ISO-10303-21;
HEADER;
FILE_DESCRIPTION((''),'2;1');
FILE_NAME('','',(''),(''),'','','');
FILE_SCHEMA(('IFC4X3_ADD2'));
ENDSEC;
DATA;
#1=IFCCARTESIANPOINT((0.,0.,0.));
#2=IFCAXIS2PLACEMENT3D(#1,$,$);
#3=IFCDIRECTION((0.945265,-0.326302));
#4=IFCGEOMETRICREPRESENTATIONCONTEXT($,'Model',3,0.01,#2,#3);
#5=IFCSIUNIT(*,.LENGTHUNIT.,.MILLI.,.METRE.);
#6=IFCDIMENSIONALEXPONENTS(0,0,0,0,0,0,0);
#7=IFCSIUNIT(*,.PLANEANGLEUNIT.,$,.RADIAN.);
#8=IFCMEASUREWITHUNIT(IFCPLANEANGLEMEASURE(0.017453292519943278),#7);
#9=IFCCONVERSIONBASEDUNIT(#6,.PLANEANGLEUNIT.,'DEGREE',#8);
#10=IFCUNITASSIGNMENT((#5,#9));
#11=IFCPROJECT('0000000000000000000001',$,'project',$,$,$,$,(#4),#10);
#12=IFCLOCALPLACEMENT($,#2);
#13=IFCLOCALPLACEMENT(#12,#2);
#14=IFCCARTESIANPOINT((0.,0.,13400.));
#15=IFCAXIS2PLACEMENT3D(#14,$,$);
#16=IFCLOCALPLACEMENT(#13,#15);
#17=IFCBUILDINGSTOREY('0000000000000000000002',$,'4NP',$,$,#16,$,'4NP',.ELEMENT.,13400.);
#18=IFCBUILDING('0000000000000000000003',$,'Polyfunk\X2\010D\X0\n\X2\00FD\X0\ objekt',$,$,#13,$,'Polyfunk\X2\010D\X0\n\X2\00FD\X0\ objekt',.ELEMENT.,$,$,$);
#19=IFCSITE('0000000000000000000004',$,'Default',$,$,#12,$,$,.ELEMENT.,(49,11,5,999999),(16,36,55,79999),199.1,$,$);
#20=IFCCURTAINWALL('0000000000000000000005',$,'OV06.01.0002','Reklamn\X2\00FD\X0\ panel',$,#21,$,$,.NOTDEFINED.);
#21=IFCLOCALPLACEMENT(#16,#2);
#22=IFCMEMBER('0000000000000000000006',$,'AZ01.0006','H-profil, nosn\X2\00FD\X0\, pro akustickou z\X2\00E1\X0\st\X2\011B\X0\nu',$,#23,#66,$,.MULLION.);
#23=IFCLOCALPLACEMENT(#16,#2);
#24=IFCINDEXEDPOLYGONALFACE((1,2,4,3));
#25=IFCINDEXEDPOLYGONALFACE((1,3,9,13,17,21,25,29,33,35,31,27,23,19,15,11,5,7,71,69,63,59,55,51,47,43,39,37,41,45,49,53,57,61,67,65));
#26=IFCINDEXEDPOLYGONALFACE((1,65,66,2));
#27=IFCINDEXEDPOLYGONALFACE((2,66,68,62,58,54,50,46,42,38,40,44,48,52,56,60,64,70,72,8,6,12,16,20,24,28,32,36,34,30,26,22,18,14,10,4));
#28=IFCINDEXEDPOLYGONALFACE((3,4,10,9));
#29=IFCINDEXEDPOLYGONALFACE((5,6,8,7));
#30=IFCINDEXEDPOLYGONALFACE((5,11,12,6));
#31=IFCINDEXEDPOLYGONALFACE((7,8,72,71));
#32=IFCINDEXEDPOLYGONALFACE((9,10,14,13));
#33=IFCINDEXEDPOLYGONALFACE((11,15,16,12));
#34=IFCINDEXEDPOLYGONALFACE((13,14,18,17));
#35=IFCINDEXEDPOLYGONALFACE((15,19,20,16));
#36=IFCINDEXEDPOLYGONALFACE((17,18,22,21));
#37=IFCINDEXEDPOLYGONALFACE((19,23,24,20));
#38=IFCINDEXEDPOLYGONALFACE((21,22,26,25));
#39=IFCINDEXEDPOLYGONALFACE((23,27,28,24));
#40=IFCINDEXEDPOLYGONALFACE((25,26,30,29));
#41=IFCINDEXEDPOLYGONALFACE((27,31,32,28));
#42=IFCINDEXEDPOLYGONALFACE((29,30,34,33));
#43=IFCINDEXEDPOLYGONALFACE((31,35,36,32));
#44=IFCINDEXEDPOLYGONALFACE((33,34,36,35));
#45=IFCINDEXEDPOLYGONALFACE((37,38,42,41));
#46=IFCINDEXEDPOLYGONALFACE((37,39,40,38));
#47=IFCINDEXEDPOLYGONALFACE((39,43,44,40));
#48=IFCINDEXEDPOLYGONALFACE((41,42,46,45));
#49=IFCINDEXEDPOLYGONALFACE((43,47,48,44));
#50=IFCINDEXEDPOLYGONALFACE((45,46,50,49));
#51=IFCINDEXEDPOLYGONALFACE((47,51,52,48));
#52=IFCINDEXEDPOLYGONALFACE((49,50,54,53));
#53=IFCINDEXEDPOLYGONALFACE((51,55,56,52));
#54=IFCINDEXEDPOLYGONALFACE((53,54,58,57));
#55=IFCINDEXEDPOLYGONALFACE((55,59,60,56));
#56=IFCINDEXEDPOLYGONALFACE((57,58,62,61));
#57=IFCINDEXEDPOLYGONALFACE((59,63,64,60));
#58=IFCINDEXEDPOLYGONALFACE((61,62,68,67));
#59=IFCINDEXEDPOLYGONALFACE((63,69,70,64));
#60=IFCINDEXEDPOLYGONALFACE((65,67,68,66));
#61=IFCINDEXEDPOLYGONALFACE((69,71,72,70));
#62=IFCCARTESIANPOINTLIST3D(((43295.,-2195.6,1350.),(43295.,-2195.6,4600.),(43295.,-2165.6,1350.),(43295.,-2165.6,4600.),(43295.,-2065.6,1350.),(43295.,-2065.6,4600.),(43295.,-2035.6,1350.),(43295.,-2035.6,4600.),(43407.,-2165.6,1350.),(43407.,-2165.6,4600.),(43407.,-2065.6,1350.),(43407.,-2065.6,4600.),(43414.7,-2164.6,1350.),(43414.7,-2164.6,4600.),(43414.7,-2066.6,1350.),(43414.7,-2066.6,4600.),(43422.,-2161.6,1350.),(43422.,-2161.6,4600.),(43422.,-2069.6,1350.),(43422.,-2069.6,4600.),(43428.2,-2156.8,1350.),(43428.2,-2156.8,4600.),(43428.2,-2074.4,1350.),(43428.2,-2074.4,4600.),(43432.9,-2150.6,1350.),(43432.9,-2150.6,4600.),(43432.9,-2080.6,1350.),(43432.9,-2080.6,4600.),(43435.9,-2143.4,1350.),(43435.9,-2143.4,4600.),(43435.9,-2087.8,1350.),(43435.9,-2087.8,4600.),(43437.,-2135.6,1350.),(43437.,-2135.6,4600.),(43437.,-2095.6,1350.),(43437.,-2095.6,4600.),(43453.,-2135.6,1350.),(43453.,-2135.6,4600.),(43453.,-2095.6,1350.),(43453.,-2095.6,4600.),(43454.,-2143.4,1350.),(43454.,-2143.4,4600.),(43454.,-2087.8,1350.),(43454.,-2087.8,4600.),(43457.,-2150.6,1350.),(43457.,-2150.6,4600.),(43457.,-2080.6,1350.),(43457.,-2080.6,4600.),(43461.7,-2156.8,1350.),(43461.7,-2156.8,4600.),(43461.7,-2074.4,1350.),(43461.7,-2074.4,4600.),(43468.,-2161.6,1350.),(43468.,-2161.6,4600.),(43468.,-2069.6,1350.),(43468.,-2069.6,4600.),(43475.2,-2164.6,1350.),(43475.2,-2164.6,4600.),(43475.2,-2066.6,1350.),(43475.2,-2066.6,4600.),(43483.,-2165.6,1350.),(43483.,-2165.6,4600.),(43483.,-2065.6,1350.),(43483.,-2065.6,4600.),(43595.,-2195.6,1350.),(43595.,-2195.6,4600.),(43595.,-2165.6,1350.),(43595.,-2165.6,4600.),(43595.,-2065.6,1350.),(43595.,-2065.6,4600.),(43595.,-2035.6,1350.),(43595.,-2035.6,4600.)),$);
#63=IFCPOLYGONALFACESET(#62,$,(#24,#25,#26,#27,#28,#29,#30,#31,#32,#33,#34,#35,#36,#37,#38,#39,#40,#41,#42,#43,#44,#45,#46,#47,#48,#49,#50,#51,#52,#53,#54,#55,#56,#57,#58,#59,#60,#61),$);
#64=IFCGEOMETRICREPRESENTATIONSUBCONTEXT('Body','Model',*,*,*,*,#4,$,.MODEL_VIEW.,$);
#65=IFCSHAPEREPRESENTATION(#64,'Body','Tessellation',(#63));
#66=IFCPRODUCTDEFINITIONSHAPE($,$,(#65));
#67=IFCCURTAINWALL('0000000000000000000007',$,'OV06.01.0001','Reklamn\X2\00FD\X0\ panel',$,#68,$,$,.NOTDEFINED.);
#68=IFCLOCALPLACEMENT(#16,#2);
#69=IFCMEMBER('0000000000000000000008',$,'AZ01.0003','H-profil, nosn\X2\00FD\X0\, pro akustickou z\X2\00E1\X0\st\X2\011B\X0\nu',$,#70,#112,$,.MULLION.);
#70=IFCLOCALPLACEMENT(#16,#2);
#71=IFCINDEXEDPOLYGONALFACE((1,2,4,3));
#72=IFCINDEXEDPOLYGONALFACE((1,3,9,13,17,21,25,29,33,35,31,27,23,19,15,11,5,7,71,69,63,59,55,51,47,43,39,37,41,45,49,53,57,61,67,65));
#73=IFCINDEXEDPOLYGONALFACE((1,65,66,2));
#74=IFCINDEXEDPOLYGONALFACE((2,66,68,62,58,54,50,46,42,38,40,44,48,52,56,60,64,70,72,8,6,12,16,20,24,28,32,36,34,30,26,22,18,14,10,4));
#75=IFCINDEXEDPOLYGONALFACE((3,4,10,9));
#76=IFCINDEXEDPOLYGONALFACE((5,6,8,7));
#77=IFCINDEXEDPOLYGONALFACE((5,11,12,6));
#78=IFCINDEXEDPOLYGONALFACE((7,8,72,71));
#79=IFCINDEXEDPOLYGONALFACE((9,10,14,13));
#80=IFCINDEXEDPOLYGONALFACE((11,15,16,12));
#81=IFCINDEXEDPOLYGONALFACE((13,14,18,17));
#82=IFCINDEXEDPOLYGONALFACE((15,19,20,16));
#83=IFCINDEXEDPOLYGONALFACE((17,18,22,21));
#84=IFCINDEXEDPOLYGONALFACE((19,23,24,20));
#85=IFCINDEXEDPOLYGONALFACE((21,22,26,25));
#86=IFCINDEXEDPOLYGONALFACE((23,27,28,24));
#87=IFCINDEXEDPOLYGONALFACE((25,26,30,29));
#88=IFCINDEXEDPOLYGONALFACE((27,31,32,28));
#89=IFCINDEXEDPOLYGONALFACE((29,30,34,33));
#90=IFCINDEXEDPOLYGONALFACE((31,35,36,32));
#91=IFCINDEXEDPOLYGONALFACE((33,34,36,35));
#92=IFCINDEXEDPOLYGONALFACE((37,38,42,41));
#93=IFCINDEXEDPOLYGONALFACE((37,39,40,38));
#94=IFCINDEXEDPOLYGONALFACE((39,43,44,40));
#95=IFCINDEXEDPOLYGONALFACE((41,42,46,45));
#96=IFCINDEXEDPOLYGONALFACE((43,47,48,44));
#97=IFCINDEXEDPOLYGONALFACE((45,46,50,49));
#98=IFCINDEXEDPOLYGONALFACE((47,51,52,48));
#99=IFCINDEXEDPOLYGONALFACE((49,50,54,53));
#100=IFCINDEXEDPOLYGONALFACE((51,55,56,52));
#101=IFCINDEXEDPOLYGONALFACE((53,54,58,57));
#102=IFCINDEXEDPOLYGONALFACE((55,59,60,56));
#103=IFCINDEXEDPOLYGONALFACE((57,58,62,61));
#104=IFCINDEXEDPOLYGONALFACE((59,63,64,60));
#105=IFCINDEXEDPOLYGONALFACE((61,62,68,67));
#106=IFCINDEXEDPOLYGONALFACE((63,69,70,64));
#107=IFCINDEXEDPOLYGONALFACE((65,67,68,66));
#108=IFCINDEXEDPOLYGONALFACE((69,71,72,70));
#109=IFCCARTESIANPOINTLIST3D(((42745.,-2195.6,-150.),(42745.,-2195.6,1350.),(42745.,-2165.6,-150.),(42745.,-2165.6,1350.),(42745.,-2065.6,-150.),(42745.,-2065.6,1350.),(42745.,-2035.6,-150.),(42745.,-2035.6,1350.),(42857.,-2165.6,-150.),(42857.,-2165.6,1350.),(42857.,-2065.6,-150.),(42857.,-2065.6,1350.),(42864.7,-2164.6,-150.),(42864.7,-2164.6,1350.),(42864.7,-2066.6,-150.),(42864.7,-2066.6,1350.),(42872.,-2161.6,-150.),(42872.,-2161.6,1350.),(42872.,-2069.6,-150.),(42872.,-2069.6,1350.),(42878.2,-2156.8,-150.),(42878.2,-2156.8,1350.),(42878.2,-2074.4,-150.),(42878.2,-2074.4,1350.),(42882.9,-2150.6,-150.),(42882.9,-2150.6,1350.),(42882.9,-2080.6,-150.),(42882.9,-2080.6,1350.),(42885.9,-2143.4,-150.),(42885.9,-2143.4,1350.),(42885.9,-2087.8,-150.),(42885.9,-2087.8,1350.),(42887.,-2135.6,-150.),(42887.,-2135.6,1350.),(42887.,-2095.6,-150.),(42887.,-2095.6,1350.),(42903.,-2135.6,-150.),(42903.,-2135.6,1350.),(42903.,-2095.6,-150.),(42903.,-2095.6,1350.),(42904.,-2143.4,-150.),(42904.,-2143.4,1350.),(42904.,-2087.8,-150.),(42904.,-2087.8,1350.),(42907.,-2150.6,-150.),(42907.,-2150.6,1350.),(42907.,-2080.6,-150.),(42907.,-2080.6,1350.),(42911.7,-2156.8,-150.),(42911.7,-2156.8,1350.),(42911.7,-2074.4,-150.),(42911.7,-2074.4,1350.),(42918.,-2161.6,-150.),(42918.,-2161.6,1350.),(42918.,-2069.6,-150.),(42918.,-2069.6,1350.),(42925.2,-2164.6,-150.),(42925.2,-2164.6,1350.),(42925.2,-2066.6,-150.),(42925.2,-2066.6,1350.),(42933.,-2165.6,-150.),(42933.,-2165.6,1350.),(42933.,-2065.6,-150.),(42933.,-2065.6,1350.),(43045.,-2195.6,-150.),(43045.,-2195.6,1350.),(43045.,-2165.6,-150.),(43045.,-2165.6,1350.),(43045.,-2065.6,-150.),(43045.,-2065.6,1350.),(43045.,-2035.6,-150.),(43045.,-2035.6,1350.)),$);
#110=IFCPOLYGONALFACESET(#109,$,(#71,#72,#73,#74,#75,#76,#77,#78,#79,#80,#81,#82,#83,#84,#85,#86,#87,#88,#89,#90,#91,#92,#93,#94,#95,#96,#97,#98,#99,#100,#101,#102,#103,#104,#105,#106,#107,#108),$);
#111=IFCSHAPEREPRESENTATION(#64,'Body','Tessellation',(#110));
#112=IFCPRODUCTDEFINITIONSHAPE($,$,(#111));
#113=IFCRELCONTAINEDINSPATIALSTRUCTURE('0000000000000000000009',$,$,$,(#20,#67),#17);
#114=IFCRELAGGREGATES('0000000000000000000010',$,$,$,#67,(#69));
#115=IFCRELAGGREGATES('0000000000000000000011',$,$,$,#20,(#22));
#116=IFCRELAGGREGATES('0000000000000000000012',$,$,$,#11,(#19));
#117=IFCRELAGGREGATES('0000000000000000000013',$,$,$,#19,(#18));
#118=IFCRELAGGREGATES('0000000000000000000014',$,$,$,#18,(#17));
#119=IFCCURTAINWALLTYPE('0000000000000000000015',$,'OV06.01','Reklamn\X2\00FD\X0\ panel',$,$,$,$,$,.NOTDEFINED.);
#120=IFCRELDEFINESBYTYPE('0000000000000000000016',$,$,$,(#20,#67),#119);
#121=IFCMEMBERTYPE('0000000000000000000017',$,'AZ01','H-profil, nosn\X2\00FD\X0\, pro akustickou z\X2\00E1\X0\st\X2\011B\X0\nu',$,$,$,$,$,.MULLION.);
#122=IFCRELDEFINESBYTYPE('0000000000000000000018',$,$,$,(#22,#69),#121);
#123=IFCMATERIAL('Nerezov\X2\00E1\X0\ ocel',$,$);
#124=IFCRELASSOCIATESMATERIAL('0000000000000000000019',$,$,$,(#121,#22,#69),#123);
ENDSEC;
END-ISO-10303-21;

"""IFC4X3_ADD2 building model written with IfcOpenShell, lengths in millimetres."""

from ifc_helpers import new_model, entity, si_unit, converted_unit, direction, frame, frame_2d, origin, place, context, subcontext, project, spatial, polyline, circle_curve, parameter, trimmed, segment, composite_curve, outline, extrude, source, transform, mapped, material, material_profile, profile_set, profile_usage, type_object, element, aggregate, save


model = new_model("IFC4X3_ADD2")

# Units and contexts
model_context = context("Model", 3, precision=0.01, world=origin(), true_north=direction((0.945265, -0.326302)))
body_context = subcontext(model_context, "Body", "Model", "MODEL_VIEW")
ifc_project = project(units=[si_unit("LENGTHUNIT", "METRE", prefix="MILLI"), converted_unit("PLANEANGLEUNIT", "DEGREE", entity("IfcPlaneAngleMeasure", 0.017453292519943278), si_unit("PLANEANGLEUNIT", "RADIAN"), dimensions=[0, 0, 0, 0, 0, 0, 0])], contexts=[model_context])

# Site, building, storey
site_placement = place(None, origin())
site = spatial("IfcSite", under=ifc_project, at=site_placement, Name="Default", CompositionType="ELEMENT", RefLatitude=(49, 11, 5, 999999), RefLongitude=(16, 36, 55, 79999), RefElevation=199.1)
building_placement = place(site_placement, origin())
building = spatial("IfcBuilding", under=site, at=building_placement, Name="Polyfunkčný objekt", LongName="Polyfunkčný objekt", CompositionType="ELEMENT")
storey_placement = place(building_placement, frame((0.0, 0.0, 13400.0)))
storey = spatial("IfcBuildingStorey", under=building, at=storey_placement, Name="4NP", LongName="4NP", CompositionType="ELEMENT", Elevation=13400.0)

# Curtain walls, members
curtain_wall_type = type_object("IfcCurtainWallType", Name="OV06.01", Description="Reklamný panel", PredefinedType="NOTDEFINED")
curtain_wall_1_placement = place(storey_placement, frame((0.0, 0.0, -13400.0)))
curtain_wall_1 = element("IfcCurtainWall", 1, at=curtain_wall_1_placement, inside=storey, type_object=curtain_wall_type, Name="OV06.01.0002", Description="Reklamný panel", PredefinedType="NOTDEFINED")
ifc_material_1 = material(Name="Nerezová ocel")
ifc_material_profile = material_profile(ifc_material_1, outline(composite_curve([segment(polyline([(50.0, -150.0), (80.0, -150.0)]), True, "CONTINUOUS"), segment(polyline([(80.0, -150.0), (80.0, 150.0)]), True, "CONTINUOUS"), segment(polyline([(80.0, 150.0), (50.0, 150.0)]), True, "CONTINUOUS"), segment(polyline([(50.0, 150.0), (50.0, 38.0)]), True, "CONTINUOUS"), segment(trimmed(circle_curve(frame_2d((20.0, 38.0), x_axis=(0.0, 1.0)), 30.0), [parameter(180.0)], [parameter(270.0)], True, "PARAMETER"), False, "CONTINUOUS"), segment(polyline([(20.0, 8.0), (-20.0, 8.0)]), True, "CONTINUOUS"), segment(trimmed(circle_curve(frame_2d((-20.0, 38.0), x_axis=(0.0, 1.0)), 30.0), [parameter(90.0)], [parameter(180.0)], True, "PARAMETER"), False, "CONTINUOUS"), segment(polyline([(-50.0, 38.0), (-50.0, 150.0)]), True, "CONTINUOUS"), segment(polyline([(-50.0, 150.0), (-80.0, 150.0)]), True, "CONTINUOUS"), segment(polyline([(-80.0, 150.0), (-80.0, -150.0)]), True, "CONTINUOUS"), segment(polyline([(-80.0, -150.0), (-50.0, -150.0)]), True, "CONTINUOUS"), segment(polyline([(-50.0, -150.0), (-50.0, -38.0)]), True, "CONTINUOUS"), segment(trimmed(circle_curve(frame_2d((-20.0, -38.0), x_axis=(0.0, 1.0)), 30.0), [parameter(0.0)], [parameter(90.0)], True, "PARAMETER"), False, "CONTINUOUS"), segment(polyline([(-20.0, -8.0), (20.0, -8.0)]), True, "CONTINUOUS"), segment(trimmed(circle_curve(frame_2d((20.0, -38.0), x_axis=(0.0, 1.0)), 30.0), [parameter(270.0)], [parameter(0.0)], True, "PARAMETER"), False, "CONTINUOUS"), segment(polyline([(50.0, -38.0), (50.0, -150.0)]), True, "CONTINUOUS")], self_intersect=False)), Name="Profil zástena")
ifc_profile_set = profile_set([ifc_material_profile], Name="Profil zástena")
ifc_profile_usage = profile_usage(ifc_profile_set)
member_type_1 = type_object("IfcMemberType", Name="AZ01", Description="H-profil, nosný, pro akustickou zástěnu", PredefinedType="MULLION", material=ifc_profile_set)
shared_shape_1 = source(origin(), body_context, "Body", "SweptSolid", [
    extrude(outline(composite_curve([segment(polyline([(50.0, -150.0), (80.0, -150.0)]), True, "CONTINUOUS"), segment(polyline([(80.0, -150.0), (80.0, 150.0)]), True, "CONTINUOUS"), segment(polyline([(80.0, 150.0), (50.0, 150.0)]), True, "CONTINUOUS"), segment(polyline([(50.0, 150.0), (50.0, 38.0)]), True, "CONTINUOUS"), segment(trimmed(circle_curve(frame_2d((20.0, 38.0), x_axis=(0.0, 1.0)), 30.0), [parameter(180.0)], [parameter(270.0)], True, "PARAMETER"), False, "CONTINUOUS"), segment(polyline([(20.0, 8.0), (-20.0, 8.0)]), True, "CONTINUOUS"), segment(trimmed(circle_curve(frame_2d((-20.0, 38.0), x_axis=(0.0, 1.0)), 30.0), [parameter(90.0)], [parameter(180.0)], True, "PARAMETER"), False, "CONTINUOUS"), segment(polyline([(-50.0, 38.0), (-50.0, 150.0)]), True, "CONTINUOUS"), segment(polyline([(-50.0, 150.0), (-80.0, 150.0)]), True, "CONTINUOUS"), segment(polyline([(-80.0, 150.0), (-80.0, -150.0)]), True, "CONTINUOUS"), segment(polyline([(-80.0, -150.0), (-50.0, -150.0)]), True, "CONTINUOUS"), segment(polyline([(-50.0, -150.0), (-50.0, -38.0)]), True, "CONTINUOUS"), segment(trimmed(circle_curve(frame_2d((-20.0, -38.0), x_axis=(0.0, 1.0)), 30.0), [parameter(0.0)], [parameter(90.0)], True, "PARAMETER"), False, "CONTINUOUS"), segment(polyline([(-20.0, -8.0), (20.0, -8.0)]), True, "CONTINUOUS"), segment(trimmed(circle_curve(frame_2d((20.0, -38.0), x_axis=(0.0, 1.0)), 30.0), [parameter(270.0)], [parameter(0.0)], True, "PARAMETER"), False, "CONTINUOUS"), segment(polyline([(50.0, -38.0), (50.0, -150.0)]), True, "CONTINUOUS")], self_intersect=False)), frame((-150.0, 0.0, -3250.0), z_axis=(0.0, 0.0, 1.0), x_axis=(0.0, 1.0, 0.0)), (0.0, 0.0, 1.0), 3250.0),
])
member_1_placement = place(curtain_wall_1_placement, frame((43295.0, -2115.6, 18000.0), z_axis=(0.0, 0.0, 1.0), x_axis=(-1.0, 0.0, 0.0)))
member_1 = element("IfcMember", 2, at=member_1_placement, type_object=member_type_1, material=ifc_profile_usage, Name="AZ01.0006", Description="H-profil, nosný, pro akustickou zástěnu", PredefinedType="MULLION", context=body_context, shape_type="MappedRepresentation", body=[
    mapped(shared_shape_1, transform((0.0, 0.0, 0.0), scale=1.0)),
])
curtain_wall_2_placement = place(storey_placement, frame((0.0, 0.0, -13400.0)))
curtain_wall_2 = element("IfcCurtainWall", 3, at=curtain_wall_2_placement, inside=storey, type_object=curtain_wall_type, Name="OV06.01.0001", Description="Reklamný panel", PredefinedType="NOTDEFINED")
shared_shape_2 = source(origin(), body_context, "Body", "SweptSolid", [
    extrude(outline(composite_curve([segment(polyline([(-150.0, -50.0), (-150.0, -80.0)]), True, "CONTINUOUS"), segment(polyline([(-150.0, -80.0), (150.0, -80.0)]), True, "CONTINUOUS"), segment(polyline([(150.0, -80.0), (150.0, -50.0)]), True, "CONTINUOUS"), segment(polyline([(150.0, -50.0), (38.0, -50.0)]), True, "CONTINUOUS"), segment(trimmed(circle_curve(frame_2d((38.0, -20.0), x_axis=(1.0, 0.0)), 30.0), [parameter(180.0)], [parameter(270.0)], True, "PARAMETER"), False, "CONTINUOUS"), segment(polyline([(8.0, -20.0), (8.0, 20.0)]), True, "CONTINUOUS"), segment(trimmed(circle_curve(frame_2d((38.0, 20.0), x_axis=(1.0, 0.0)), 30.0), [parameter(90.0)], [parameter(180.0)], True, "PARAMETER"), False, "CONTINUOUS"), segment(polyline([(38.0, 50.0), (150.0, 50.0)]), True, "CONTINUOUS"), segment(polyline([(150.0, 50.0), (150.0, 80.0)]), True, "CONTINUOUS"), segment(polyline([(150.0, 80.0), (-150.0, 80.0)]), True, "CONTINUOUS"), segment(polyline([(-150.0, 80.0), (-150.0, 50.0)]), True, "CONTINUOUS"), segment(polyline([(-150.0, 50.0), (-38.0, 50.0)]), True, "CONTINUOUS"), segment(trimmed(circle_curve(frame_2d((-38.0, 20.0), x_axis=(1.0, 0.0)), 30.0), [parameter(0.0)], [parameter(90.0)], True, "PARAMETER"), False, "CONTINUOUS"), segment(polyline([(-8.0, 20.0), (-8.0, -20.0)]), True, "CONTINUOUS"), segment(trimmed(circle_curve(frame_2d((-38.0, -20.0), x_axis=(1.0, 0.0)), 30.0), [parameter(270.0)], [parameter(0.0)], True, "PARAMETER"), False, "CONTINUOUS"), segment(polyline([(-38.0, -50.0), (-150.0, -50.0)]), True, "CONTINUOUS")], self_intersect=False)), frame((-150.0, 0.0, -1500.0), z_axis=(0.0, 0.0, -1.0), x_axis=(1.0, 0.0, 0.0)), (0.0, 0.0, -1.0), 1500.0),
])
member_2_placement = place(curtain_wall_2_placement, frame((43045.0, -2115.6, 13250.0), z_axis=(0.0, 0.0, -1.0), x_axis=(1.0, 0.0, 0.0)))
member_2 = element("IfcMember", 4, at=member_2_placement, type_object=member_type_1, material=ifc_profile_usage, Name="AZ01.0003", Description="H-profil, nosný, pro akustickou zástěnu", PredefinedType="MULLION", context=body_context, shape_type="MappedRepresentation", body=[
    mapped(shared_shape_2, transform((0.0, 0.0, 0.0), scale=1.0)),
])

aggregate(curtain_wall_2, [member_2])
aggregate(curtain_wall_1, [member_1])

save(model, "model.ifc")
